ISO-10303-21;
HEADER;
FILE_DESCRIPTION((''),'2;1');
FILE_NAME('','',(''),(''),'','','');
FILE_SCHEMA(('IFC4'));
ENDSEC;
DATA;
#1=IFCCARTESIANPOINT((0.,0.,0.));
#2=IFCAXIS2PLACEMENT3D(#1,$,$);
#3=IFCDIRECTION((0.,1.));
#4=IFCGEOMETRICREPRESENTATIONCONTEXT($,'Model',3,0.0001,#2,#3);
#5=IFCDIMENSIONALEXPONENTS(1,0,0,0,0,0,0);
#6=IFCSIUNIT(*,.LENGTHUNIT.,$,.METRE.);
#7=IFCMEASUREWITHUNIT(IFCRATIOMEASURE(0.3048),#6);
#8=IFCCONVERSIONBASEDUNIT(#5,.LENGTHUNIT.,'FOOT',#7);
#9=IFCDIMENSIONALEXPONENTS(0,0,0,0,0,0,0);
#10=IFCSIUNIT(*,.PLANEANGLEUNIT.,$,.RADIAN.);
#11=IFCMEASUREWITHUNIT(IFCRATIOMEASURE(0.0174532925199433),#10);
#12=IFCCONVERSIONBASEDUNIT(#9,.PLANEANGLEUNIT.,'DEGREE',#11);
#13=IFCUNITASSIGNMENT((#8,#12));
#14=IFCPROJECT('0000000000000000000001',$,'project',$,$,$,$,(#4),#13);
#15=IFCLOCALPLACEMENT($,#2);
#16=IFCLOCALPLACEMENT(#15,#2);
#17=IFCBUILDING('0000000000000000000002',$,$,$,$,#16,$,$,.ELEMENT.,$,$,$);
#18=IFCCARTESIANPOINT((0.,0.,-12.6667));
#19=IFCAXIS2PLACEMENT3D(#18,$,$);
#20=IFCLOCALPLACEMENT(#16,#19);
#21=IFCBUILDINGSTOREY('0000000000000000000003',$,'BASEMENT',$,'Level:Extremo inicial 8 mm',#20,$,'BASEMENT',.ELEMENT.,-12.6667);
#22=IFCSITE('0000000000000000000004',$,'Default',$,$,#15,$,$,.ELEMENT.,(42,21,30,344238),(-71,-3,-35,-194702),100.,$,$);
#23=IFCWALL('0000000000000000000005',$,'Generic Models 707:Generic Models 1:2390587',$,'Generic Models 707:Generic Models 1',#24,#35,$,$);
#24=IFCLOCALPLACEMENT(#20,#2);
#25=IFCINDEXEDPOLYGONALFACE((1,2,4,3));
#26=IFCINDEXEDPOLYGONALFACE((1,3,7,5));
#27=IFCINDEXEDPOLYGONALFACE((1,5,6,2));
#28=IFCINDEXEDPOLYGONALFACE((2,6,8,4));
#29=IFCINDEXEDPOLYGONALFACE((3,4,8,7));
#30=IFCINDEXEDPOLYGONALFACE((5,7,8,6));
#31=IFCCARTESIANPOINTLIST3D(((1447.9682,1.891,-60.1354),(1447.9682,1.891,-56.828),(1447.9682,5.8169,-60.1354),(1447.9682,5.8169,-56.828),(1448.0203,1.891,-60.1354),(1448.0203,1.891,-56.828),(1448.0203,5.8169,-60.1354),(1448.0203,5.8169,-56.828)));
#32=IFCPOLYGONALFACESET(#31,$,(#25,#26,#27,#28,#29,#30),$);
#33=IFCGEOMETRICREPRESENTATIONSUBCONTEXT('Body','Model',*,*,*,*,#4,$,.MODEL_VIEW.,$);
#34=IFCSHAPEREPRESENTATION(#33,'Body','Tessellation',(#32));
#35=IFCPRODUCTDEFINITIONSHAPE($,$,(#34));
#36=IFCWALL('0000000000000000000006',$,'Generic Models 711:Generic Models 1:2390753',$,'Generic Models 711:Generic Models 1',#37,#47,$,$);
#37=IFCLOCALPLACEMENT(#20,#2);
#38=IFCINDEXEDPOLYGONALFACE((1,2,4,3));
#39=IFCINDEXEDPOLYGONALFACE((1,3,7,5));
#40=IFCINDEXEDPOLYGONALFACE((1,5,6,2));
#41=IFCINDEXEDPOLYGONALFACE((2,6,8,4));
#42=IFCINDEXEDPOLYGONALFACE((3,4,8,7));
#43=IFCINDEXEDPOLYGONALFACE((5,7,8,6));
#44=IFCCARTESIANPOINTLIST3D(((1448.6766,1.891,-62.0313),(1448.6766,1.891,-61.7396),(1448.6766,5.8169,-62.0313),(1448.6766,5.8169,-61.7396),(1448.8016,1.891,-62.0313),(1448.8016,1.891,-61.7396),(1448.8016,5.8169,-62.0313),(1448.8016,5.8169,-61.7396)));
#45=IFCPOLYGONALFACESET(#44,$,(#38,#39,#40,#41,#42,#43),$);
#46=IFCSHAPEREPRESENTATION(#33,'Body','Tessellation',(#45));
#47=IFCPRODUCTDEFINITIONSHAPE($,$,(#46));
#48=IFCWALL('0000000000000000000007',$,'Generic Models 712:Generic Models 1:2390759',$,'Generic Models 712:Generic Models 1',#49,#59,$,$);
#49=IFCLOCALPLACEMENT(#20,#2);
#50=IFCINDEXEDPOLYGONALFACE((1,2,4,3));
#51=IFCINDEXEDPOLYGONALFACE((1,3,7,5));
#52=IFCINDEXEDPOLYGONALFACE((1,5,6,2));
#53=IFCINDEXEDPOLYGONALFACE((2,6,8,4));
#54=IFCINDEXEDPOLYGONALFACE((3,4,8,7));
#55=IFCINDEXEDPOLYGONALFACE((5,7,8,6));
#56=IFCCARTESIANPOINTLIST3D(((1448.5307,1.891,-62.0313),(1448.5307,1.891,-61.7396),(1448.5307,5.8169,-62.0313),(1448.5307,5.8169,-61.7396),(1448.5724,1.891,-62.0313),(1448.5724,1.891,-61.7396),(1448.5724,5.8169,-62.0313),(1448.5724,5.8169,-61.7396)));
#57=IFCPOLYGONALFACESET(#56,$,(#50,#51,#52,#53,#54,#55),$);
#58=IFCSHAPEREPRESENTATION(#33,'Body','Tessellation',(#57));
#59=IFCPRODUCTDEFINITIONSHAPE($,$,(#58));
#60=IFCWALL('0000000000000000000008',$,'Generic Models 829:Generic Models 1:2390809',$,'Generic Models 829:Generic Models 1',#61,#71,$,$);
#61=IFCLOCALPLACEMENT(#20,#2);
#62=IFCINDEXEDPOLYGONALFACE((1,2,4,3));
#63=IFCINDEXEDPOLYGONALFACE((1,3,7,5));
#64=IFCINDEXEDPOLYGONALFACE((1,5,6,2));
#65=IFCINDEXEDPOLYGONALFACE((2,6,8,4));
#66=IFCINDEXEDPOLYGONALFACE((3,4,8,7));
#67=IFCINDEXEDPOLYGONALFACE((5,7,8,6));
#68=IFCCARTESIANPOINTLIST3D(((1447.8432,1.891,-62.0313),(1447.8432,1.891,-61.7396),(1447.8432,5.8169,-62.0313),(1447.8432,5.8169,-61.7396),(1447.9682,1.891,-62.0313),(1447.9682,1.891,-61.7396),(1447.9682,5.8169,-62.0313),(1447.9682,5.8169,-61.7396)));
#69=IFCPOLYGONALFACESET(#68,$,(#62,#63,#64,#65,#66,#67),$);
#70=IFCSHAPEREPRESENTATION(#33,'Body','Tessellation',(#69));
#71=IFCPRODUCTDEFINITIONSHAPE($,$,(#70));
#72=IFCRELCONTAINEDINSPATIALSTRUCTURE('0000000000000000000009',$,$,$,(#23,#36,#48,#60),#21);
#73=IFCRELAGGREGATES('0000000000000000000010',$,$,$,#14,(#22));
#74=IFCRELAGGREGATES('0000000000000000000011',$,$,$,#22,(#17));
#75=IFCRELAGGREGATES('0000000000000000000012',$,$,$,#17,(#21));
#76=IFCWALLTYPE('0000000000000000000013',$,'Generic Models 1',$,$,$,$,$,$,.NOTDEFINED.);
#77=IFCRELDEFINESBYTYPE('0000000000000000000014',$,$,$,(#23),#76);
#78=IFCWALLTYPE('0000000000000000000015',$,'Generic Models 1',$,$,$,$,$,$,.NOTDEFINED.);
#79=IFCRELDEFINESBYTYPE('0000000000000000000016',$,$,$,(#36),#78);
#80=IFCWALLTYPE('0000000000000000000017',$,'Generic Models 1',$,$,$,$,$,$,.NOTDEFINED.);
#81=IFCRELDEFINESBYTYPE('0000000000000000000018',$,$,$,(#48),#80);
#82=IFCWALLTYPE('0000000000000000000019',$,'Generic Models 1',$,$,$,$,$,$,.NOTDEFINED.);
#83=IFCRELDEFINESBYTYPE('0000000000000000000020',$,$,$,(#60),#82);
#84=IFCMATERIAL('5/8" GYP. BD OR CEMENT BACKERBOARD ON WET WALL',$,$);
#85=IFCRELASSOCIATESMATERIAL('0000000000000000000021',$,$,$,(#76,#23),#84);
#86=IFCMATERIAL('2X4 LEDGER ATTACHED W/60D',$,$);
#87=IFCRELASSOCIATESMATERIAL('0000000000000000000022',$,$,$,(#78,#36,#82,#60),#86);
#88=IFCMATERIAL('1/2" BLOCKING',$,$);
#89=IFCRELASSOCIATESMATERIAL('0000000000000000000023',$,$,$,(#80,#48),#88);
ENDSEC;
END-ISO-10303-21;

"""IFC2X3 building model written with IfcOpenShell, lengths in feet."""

from ifc_helpers import new_model, entity, si_unit, converted_unit, direction, frame, frame_2d, origin, place, context, subcontext, project, spatial, rectangle, extrude, material, type_object, element, save


model = new_model("IFC2X3")

# Units and contexts
model_context = context("Model", 3, precision=0.0001, world=origin(), true_north=direction((0.0, 1.0)))
body_context = subcontext(model_context, "Body", "Model", "MODEL_VIEW")
ifc_project = project(units=[converted_unit("LENGTHUNIT", "FOOT", entity("IfcRatioMeasure", 0.3048), si_unit("LENGTHUNIT", "METRE"), dimensions=[1, 0, 0, 0, 0, 0, 0]), converted_unit("PLANEANGLEUNIT", "DEGREE", entity("IfcRatioMeasure", 0.0174532925199433), si_unit("PLANEANGLEUNIT", "RADIAN"), dimensions=[0, 0, 0, 0, 0, 0, 0])], contexts=[model_context])

# Site, building, storey
site_placement = place(None, origin())
site = spatial("IfcSite", under=ifc_project, at=site_placement, Name="Default", CompositionType="ELEMENT", RefLatitude=(42, 21, 30, 344238), RefLongitude=(-71, -3, -35, -194702), RefElevation=100.0)
building_placement = place(site_placement, origin())
building = spatial("IfcBuilding", under=site, at=building_placement, CompositionType="ELEMENT")
storey_placement = place(building_placement, frame((0.0, 0.0, -12.6667)))
storey = spatial("IfcBuildingStorey", under=building, at=storey_placement, Name="BASEMENT", ObjectType="Level:Extremo inicial 8 mm", LongName="BASEMENT", CompositionType="ELEMENT", Elevation=-12.6667)

# Walls
ifc_material_1 = material(Name="2X4 LEDGER ATTACHED W/60D")
ifc_material_2 = material(Name="5/8\" GYP. BD OR CEMENT BACKERBOARD ON WET WALL")
wall_type_1 = type_object("IfcWallType", Name="Generic Models 1", PredefinedType="NOTDEFINED", material=ifc_material_2)
wall_1_placement = place(storey_placement, frame((1447.9682, 1.891, -60.1354), z_axis=(0.0, 0.0, 1.0), x_axis=(0.0, 1.0, 0.0)))
element("IfcWall", 1, at=wall_1_placement, inside=storey, type_object=wall_type_1, material=ifc_material_2, Name="Generic Models 707:Generic Models 1:2390587", ObjectType="Generic Models 707:Generic Models 1", context=body_context, shape_type="SweptSolid", body=[
    extrude(rectangle(XDim=3.9258, YDim=0.0521, at=frame_2d((0.0, 0.0), x_axis=(1.0, 0.0))), frame((1.9629, -0.026, 0.0)), (0.0, 0.0, 1.0), 3.3074),
])
wall_type_2 = type_object("IfcWallType", Name="Generic Models 1", PredefinedType="NOTDEFINED", material=ifc_material_1)
wall_2_placement = place(storey_placement, frame((1448.6766, 1.891, -62.0313), z_axis=(0.0, 0.0, 1.0), x_axis=(0.0, 1.0, 0.0)))
element("IfcWall", 2, at=wall_2_placement, inside=storey, type_object=wall_type_2, material=ifc_material_1, Name="Generic Models 711:Generic Models 1:2390753", ObjectType="Generic Models 711:Generic Models 1", context=body_context, shape_type="SweptSolid", body=[
    extrude(rectangle(XDim=3.9258, YDim=0.125, at=frame_2d((0.0, 0.0), x_axis=(1.0, 0.0))), frame((1.9629, -0.0625, 0.0)), (0.0, 0.0, 1.0), 0.2917),
])
ifc_material_3 = material(Name="1/2\" BLOCKING")
wall_type_3 = type_object("IfcWallType", Name="Generic Models 1", PredefinedType="NOTDEFINED", material=ifc_material_3)
wall_3_placement = place(storey_placement, frame((1448.5307, 1.891, -62.0313), z_axis=(0.0, 0.0, 1.0), x_axis=(0.0, 1.0, 0.0)))
element("IfcWall", 3, at=wall_3_placement, inside=storey, type_object=wall_type_3, material=ifc_material_3, Name="Generic Models 712:Generic Models 1:2390759", ObjectType="Generic Models 712:Generic Models 1", context=body_context, shape_type="SweptSolid", body=[
    extrude(rectangle(XDim=3.9258, YDim=0.0417, at=frame_2d((0.0, 0.0), x_axis=(1.0, 0.0))), frame((1.9629, -0.0208, 0.0)), (0.0, 0.0, 1.0), 0.2917),
])
wall_type_4 = type_object("IfcWallType", Name="Generic Models 1", PredefinedType="NOTDEFINED", material=ifc_material_1)
wall_4_placement = place(storey_placement, frame((1447.8432, 1.891, -62.0313), z_axis=(0.0, 0.0, 1.0), x_axis=(0.0, 1.0, 0.0)))
element("IfcWall", 4, at=wall_4_placement, inside=storey, type_object=wall_type_4, material=ifc_material_1, Name="Generic Models 829:Generic Models 1:2390809", ObjectType="Generic Models 829:Generic Models 1", context=body_context, shape_type="SweptSolid", body=[
    extrude(rectangle(XDim=3.9258, YDim=0.125, at=frame_2d((0.0, 0.0), x_axis=(1.0, 0.0))), frame((1.9629, -0.0625, 0.0)), (0.0, 0.0, 1.0), 0.2917),
])

save(model, "model.ifc")
